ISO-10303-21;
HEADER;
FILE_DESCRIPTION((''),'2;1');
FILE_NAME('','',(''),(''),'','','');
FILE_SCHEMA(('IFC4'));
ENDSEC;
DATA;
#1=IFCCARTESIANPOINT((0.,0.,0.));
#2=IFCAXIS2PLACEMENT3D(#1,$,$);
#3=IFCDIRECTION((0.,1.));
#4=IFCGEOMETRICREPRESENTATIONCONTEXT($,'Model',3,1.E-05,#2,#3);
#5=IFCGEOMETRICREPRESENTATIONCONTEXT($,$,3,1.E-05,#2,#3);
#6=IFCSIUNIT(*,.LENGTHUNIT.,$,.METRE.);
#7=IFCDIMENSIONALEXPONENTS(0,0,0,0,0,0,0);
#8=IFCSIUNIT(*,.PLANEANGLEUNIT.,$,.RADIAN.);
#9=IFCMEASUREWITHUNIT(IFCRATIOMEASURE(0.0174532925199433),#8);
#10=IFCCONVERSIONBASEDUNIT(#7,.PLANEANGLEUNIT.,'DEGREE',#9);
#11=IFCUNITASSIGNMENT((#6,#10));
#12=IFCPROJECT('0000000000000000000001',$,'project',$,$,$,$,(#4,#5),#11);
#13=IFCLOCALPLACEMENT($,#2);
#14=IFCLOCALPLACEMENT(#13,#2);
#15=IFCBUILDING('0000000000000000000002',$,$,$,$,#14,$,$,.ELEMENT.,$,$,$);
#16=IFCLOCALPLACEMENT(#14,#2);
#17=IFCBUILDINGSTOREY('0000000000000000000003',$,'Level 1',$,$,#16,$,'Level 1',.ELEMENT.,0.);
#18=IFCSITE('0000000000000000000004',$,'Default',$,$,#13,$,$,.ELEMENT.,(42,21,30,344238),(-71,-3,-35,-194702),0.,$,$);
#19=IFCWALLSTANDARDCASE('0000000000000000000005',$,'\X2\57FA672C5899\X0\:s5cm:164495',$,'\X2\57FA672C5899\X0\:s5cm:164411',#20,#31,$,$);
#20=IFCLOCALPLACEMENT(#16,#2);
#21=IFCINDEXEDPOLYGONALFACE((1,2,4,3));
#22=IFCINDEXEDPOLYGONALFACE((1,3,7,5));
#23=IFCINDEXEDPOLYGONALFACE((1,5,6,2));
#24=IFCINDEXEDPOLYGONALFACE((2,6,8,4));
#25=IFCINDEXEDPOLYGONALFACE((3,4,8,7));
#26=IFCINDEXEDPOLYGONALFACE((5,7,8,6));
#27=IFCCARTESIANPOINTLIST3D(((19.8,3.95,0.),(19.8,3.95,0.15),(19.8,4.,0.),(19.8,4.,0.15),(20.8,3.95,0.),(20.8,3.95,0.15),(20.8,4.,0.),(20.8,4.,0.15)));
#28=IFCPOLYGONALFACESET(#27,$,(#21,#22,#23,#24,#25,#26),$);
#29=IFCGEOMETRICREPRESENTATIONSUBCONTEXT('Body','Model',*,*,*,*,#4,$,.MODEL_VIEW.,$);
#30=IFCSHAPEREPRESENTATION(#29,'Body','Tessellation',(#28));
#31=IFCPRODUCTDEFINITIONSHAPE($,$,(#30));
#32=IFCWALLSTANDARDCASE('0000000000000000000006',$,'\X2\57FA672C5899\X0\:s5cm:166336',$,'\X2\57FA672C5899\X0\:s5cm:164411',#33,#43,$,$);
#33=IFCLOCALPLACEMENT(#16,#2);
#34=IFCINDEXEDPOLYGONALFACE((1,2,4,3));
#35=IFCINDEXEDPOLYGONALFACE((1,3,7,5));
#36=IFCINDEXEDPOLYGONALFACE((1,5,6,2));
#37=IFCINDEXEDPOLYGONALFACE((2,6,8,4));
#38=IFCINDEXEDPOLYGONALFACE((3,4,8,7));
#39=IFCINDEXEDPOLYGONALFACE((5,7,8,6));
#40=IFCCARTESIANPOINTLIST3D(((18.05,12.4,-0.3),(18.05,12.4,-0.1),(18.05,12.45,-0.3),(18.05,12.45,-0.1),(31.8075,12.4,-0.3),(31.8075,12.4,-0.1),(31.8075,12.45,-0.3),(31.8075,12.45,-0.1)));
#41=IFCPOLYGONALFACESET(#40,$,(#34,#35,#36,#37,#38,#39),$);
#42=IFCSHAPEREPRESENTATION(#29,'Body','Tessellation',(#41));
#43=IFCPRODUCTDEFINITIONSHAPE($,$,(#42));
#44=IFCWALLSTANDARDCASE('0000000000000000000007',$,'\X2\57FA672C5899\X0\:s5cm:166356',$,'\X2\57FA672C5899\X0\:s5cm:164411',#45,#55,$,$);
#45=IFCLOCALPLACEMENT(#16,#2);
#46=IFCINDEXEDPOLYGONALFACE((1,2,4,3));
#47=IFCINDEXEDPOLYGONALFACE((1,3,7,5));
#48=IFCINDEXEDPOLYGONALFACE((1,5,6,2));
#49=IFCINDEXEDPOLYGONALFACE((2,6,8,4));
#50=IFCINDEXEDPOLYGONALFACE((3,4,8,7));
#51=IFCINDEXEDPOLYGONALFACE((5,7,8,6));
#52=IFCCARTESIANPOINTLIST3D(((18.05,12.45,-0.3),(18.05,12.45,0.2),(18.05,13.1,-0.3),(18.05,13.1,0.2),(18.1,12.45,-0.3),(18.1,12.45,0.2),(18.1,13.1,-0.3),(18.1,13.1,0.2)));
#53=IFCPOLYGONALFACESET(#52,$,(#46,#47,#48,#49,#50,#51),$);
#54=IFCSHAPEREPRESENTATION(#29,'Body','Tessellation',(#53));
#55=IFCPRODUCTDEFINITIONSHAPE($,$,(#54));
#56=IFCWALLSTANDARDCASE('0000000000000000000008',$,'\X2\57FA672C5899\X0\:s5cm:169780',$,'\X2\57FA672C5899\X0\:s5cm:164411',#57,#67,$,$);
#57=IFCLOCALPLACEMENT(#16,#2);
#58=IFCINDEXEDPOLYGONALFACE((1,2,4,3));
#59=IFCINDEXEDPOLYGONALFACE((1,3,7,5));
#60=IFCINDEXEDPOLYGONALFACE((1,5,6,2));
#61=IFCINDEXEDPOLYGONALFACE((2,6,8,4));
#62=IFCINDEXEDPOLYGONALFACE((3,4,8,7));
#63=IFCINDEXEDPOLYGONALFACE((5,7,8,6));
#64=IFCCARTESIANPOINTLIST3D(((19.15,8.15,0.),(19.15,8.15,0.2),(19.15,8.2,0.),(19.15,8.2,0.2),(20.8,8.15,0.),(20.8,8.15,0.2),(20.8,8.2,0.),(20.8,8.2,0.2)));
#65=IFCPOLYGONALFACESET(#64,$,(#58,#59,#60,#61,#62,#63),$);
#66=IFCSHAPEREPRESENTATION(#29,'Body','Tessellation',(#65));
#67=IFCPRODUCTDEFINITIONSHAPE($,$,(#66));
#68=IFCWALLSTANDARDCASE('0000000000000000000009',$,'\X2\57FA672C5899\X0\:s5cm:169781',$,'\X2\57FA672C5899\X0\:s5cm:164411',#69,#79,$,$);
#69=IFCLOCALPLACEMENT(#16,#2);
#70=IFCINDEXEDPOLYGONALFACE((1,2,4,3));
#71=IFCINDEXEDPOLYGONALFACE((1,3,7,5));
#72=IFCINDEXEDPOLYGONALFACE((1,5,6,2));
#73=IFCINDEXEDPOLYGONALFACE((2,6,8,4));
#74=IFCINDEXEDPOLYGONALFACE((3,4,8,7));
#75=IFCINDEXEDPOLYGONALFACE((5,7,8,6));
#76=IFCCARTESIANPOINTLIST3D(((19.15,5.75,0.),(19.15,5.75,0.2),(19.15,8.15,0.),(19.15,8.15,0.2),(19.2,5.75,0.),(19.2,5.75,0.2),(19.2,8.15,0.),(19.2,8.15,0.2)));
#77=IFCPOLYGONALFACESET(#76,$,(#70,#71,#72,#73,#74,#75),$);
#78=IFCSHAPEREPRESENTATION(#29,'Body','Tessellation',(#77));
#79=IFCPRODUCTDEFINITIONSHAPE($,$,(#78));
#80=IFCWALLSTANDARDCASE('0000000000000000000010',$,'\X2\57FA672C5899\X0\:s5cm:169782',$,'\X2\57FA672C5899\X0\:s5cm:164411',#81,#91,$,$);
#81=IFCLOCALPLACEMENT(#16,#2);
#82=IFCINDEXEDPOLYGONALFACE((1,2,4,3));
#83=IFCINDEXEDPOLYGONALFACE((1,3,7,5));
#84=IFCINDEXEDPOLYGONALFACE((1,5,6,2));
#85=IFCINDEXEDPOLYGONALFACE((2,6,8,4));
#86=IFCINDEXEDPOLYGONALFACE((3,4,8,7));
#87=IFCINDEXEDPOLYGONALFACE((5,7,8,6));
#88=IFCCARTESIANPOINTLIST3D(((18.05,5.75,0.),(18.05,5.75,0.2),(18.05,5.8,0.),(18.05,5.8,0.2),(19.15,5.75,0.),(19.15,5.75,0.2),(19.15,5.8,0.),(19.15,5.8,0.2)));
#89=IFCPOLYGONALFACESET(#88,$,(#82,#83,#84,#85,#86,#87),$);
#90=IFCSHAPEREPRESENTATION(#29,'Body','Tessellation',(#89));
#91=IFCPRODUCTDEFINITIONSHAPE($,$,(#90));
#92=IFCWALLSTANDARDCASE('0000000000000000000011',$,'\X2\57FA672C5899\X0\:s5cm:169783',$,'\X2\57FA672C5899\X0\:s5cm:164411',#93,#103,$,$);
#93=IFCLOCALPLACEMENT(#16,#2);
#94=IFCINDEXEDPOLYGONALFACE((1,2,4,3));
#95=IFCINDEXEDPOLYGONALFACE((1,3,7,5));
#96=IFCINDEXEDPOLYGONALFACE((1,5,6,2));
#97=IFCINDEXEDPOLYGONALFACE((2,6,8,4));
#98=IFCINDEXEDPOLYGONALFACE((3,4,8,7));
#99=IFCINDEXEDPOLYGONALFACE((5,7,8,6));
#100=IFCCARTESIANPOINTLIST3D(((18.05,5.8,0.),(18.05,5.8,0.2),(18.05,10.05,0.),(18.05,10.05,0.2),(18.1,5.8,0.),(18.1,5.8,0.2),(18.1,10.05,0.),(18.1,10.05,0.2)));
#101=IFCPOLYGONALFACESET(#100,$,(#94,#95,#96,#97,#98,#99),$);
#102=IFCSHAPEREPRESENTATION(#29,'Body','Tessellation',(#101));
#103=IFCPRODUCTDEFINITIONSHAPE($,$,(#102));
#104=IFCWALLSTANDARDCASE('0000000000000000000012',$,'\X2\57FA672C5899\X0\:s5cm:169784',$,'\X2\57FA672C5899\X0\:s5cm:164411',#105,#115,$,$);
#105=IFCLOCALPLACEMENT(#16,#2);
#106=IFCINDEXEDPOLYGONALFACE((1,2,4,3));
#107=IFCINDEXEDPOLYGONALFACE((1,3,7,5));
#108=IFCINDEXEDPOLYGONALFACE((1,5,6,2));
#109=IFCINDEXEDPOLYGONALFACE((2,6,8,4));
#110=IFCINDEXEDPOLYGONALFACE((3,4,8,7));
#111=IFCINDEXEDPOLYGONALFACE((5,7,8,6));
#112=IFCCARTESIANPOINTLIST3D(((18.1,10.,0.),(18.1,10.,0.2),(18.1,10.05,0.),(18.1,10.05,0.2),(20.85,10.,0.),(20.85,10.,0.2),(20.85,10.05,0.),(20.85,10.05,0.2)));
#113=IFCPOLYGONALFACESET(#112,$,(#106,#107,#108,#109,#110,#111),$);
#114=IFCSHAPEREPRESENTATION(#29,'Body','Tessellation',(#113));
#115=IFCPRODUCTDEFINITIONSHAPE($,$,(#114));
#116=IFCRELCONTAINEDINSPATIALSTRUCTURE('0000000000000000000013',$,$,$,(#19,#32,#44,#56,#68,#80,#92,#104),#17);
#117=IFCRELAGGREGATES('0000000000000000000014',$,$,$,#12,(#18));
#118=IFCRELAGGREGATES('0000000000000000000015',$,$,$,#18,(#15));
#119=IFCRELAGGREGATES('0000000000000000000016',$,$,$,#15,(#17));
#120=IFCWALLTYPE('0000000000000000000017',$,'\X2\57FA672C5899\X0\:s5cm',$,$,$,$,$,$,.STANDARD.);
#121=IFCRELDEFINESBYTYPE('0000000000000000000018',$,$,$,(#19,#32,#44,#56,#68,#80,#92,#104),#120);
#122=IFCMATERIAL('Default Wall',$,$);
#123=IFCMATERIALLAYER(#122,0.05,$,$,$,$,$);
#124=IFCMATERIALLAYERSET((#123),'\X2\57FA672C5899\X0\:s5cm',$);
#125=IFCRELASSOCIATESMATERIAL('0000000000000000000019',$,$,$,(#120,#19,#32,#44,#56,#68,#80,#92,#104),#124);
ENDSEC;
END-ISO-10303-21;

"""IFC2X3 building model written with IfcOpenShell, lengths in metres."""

from ifc_helpers import new_model, entity, si_unit, converted_unit, direction, frame, frame_2d, origin, place, context, subcontext, project, spatial, rectangle, extrude, material, layer, layer_set, layer_usage, type_object, element, save


model = new_model("IFC2X3")

# Units and contexts
model_context = context("Model", 3, precision=1e-05, world=origin(), true_north=direction((0.0, 1.0)))
context_of_model = context(None, 3, precision=1e-05, world=origin(), true_north=direction((0.0, 1.0)))
body_context = subcontext(model_context, "Body", "Model", "MODEL_VIEW")
ifc_project = project(units=[si_unit("LENGTHUNIT", "METRE"), converted_unit("PLANEANGLEUNIT", "DEGREE", entity("IfcRatioMeasure", 0.0174532925199433), si_unit("PLANEANGLEUNIT", "RADIAN"), dimensions=[0, 0, 0, 0, 0, 0, 0])], contexts=[model_context, context_of_model])

# Site, building, storey
site_placement = place(None, origin())
site = spatial("IfcSite", under=ifc_project, at=site_placement, Name="Default", CompositionType="ELEMENT", RefLatitude=(42, 21, 30, 344238), RefLongitude=(-71, -3, -35, -194702), RefElevation=0.0)
building_placement = place(site_placement, origin())
building = spatial("IfcBuilding", under=site, at=building_placement, CompositionType="ELEMENT")
storey_placement = place(building_placement, origin())
storey = spatial("IfcBuildingStorey", under=building, at=storey_placement, Name="Level 1", LongName="Level 1", CompositionType="ELEMENT", Elevation=0.0)

# Walls
ifc_material_1 = material(Name="Default Wall")
ifc_layer_1 = layer(ifc_material_1, 0.05)
ifc_layer_set_1 = layer_set([ifc_layer_1], Name="基本墙:s5cm")
wall_type = type_object("IfcWallType", Name="基本墙:s5cm", PredefinedType="STANDARD", material=ifc_layer_set_1)
ifc_layer_usage_1 = layer_usage(ifc_layer_set_1, "AXIS2", "NEGATIVE", 0.025)
wall_1_placement = place(storey_placement, frame((19.8, 3.975, 0.0)))
element("IfcWallStandardCase", 1, at=wall_1_placement, inside=storey, type_object=wall_type, material=ifc_layer_usage_1, Name="基本墙:s5cm:164495", ObjectType="基本墙:s5cm:164411", context=body_context, shape_type="SweptSolid", body=[
    extrude(rectangle(XDim=1.0, YDim=0.05, at=frame_2d((0.5, 0.0), x_axis=(-1.0, 0.0))), origin(), (0.0, 0.0, 1.0), 0.15),
])
ifc_layer_usage_2 = layer_usage(ifc_layer_set_1, "AXIS2", "NEGATIVE", 0.025)
wall_2_placement = place(storey_placement, frame((18.05, 12.425, -0.3)))
element("IfcWallStandardCase", 2, at=wall_2_placement, inside=storey, type_object=wall_type, material=ifc_layer_usage_2, Name="基本墙:s5cm:166336", ObjectType="基本墙:s5cm:164411", context=body_context, shape_type="SweptSolid", body=[
    extrude(rectangle(XDim=13.7575, YDim=0.05, at=frame_2d((6.8787, 0.0), x_axis=(-1.0, 0.0))), origin(), (0.0, 0.0, 1.0), 0.2),
])
ifc_layer_usage_3 = layer_usage(ifc_layer_set_1, "AXIS2", "NEGATIVE", 0.025)
wall_3_placement = place(storey_placement, frame((18.075, 12.45, -0.3), z_axis=(0.0, 0.0, 1.0), x_axis=(0.0, 1.0, 0.0)))
element("IfcWallStandardCase", 3, at=wall_3_placement, inside=storey, type_object=wall_type, material=ifc_layer_usage_3, Name="基本墙:s5cm:166356", ObjectType="基本墙:s5cm:164411", context=body_context, shape_type="SweptSolid", body=[
    extrude(rectangle(XDim=0.65, YDim=0.05, at=frame_2d((0.325, 0.0), x_axis=(-1.0, 0.0))), origin(), (0.0, 0.0, 1.0), 0.5),
])
ifc_layer_usage_4 = layer_usage(ifc_layer_set_1, "AXIS2", "NEGATIVE", 0.025)
wall_4_placement = place(storey_placement, frame((20.8, 8.175, 0.0), z_axis=(0.0, 0.0, 1.0), x_axis=(-1.0, 0.0, 0.0)))
element("IfcWallStandardCase", 4, at=wall_4_placement, inside=storey, type_object=wall_type, material=ifc_layer_usage_4, Name="基本墙:s5cm:169780", ObjectType="基本墙:s5cm:164411", context=body_context, shape_type="SweptSolid", body=[
    extrude(rectangle(XDim=1.65, YDim=0.05, at=frame_2d((0.825, 0.0), x_axis=(-1.0, 0.0))), origin(), (0.0, 0.0, 1.0), 0.2),
])
ifc_layer_usage_5 = layer_usage(ifc_layer_set_1, "AXIS2", "NEGATIVE", 0.025)
wall_5_placement = place(storey_placement, frame((19.175, 8.15, 0.0), z_axis=(0.0, 0.0, 1.0), x_axis=(0.0, -1.0, 0.0)))
element("IfcWallStandardCase", 5, at=wall_5_placement, inside=storey, type_object=wall_type, material=ifc_layer_usage_5, Name="基本墙:s5cm:169781", ObjectType="基本墙:s5cm:164411", context=body_context, shape_type="SweptSolid", body=[
    extrude(rectangle(XDim=2.4, YDim=0.05, at=frame_2d((1.2, 0.0), x_axis=(-1.0, 0.0))), origin(), (0.0, 0.0, 1.0), 0.2),
])
ifc_layer_usage_6 = layer_usage(ifc_layer_set_1, "AXIS2", "NEGATIVE", 0.025)
wall_6_placement = place(storey_placement, frame((19.15, 5.775, 0.0), z_axis=(0.0, 0.0, 1.0), x_axis=(-1.0, 0.0, 0.0)))
element("IfcWallStandardCase", 6, at=wall_6_placement, inside=storey, type_object=wall_type, material=ifc_layer_usage_6, Name="基本墙:s5cm:169782", ObjectType="基本墙:s5cm:164411", context=body_context, shape_type="SweptSolid", body=[
    extrude(rectangle(XDim=1.1, YDim=0.05, at=frame_2d((0.55, 0.0), x_axis=(-1.0, 0.0))), origin(), (0.0, 0.0, 1.0), 0.2),
])
ifc_layer_usage_7 = layer_usage(ifc_layer_set_1, "AXIS2", "NEGATIVE", 0.025)
wall_7_placement = place(storey_placement, frame((18.075, 5.8, 0.0), z_axis=(0.0, 0.0, 1.0), x_axis=(0.0, 1.0, 0.0)))
element("IfcWallStandardCase", 7, at=wall_7_placement, inside=storey, type_object=wall_type, material=ifc_layer_usage_7, Name="基本墙:s5cm:169783", ObjectType="基本墙:s5cm:164411", context=body_context, shape_type="SweptSolid", body=[
    extrude(rectangle(XDim=4.25, YDim=0.05, at=frame_2d((2.125, 0.0), x_axis=(-1.0, 0.0))), origin(), (0.0, 0.0, 1.0), 0.2),
])
ifc_layer_usage_8 = layer_usage(ifc_layer_set_1, "AXIS2", "NEGATIVE", 0.025)
wall_8_placement = place(storey_placement, frame((18.1, 10.025, 0.0)))
element("IfcWallStandardCase", 8, at=wall_8_placement, inside=storey, type_object=wall_type, material=ifc_layer_usage_8, Name="基本墙:s5cm:169784", ObjectType="基本墙:s5cm:164411", context=body_context, shape_type="SweptSolid", body=[
    extrude(rectangle(XDim=2.75, YDim=0.05, at=frame_2d((1.375, 0.0), x_axis=(-1.0, 0.0))), origin(), (0.0, 0.0, 1.0), 0.2),
])

save(model, "model.ifc")
